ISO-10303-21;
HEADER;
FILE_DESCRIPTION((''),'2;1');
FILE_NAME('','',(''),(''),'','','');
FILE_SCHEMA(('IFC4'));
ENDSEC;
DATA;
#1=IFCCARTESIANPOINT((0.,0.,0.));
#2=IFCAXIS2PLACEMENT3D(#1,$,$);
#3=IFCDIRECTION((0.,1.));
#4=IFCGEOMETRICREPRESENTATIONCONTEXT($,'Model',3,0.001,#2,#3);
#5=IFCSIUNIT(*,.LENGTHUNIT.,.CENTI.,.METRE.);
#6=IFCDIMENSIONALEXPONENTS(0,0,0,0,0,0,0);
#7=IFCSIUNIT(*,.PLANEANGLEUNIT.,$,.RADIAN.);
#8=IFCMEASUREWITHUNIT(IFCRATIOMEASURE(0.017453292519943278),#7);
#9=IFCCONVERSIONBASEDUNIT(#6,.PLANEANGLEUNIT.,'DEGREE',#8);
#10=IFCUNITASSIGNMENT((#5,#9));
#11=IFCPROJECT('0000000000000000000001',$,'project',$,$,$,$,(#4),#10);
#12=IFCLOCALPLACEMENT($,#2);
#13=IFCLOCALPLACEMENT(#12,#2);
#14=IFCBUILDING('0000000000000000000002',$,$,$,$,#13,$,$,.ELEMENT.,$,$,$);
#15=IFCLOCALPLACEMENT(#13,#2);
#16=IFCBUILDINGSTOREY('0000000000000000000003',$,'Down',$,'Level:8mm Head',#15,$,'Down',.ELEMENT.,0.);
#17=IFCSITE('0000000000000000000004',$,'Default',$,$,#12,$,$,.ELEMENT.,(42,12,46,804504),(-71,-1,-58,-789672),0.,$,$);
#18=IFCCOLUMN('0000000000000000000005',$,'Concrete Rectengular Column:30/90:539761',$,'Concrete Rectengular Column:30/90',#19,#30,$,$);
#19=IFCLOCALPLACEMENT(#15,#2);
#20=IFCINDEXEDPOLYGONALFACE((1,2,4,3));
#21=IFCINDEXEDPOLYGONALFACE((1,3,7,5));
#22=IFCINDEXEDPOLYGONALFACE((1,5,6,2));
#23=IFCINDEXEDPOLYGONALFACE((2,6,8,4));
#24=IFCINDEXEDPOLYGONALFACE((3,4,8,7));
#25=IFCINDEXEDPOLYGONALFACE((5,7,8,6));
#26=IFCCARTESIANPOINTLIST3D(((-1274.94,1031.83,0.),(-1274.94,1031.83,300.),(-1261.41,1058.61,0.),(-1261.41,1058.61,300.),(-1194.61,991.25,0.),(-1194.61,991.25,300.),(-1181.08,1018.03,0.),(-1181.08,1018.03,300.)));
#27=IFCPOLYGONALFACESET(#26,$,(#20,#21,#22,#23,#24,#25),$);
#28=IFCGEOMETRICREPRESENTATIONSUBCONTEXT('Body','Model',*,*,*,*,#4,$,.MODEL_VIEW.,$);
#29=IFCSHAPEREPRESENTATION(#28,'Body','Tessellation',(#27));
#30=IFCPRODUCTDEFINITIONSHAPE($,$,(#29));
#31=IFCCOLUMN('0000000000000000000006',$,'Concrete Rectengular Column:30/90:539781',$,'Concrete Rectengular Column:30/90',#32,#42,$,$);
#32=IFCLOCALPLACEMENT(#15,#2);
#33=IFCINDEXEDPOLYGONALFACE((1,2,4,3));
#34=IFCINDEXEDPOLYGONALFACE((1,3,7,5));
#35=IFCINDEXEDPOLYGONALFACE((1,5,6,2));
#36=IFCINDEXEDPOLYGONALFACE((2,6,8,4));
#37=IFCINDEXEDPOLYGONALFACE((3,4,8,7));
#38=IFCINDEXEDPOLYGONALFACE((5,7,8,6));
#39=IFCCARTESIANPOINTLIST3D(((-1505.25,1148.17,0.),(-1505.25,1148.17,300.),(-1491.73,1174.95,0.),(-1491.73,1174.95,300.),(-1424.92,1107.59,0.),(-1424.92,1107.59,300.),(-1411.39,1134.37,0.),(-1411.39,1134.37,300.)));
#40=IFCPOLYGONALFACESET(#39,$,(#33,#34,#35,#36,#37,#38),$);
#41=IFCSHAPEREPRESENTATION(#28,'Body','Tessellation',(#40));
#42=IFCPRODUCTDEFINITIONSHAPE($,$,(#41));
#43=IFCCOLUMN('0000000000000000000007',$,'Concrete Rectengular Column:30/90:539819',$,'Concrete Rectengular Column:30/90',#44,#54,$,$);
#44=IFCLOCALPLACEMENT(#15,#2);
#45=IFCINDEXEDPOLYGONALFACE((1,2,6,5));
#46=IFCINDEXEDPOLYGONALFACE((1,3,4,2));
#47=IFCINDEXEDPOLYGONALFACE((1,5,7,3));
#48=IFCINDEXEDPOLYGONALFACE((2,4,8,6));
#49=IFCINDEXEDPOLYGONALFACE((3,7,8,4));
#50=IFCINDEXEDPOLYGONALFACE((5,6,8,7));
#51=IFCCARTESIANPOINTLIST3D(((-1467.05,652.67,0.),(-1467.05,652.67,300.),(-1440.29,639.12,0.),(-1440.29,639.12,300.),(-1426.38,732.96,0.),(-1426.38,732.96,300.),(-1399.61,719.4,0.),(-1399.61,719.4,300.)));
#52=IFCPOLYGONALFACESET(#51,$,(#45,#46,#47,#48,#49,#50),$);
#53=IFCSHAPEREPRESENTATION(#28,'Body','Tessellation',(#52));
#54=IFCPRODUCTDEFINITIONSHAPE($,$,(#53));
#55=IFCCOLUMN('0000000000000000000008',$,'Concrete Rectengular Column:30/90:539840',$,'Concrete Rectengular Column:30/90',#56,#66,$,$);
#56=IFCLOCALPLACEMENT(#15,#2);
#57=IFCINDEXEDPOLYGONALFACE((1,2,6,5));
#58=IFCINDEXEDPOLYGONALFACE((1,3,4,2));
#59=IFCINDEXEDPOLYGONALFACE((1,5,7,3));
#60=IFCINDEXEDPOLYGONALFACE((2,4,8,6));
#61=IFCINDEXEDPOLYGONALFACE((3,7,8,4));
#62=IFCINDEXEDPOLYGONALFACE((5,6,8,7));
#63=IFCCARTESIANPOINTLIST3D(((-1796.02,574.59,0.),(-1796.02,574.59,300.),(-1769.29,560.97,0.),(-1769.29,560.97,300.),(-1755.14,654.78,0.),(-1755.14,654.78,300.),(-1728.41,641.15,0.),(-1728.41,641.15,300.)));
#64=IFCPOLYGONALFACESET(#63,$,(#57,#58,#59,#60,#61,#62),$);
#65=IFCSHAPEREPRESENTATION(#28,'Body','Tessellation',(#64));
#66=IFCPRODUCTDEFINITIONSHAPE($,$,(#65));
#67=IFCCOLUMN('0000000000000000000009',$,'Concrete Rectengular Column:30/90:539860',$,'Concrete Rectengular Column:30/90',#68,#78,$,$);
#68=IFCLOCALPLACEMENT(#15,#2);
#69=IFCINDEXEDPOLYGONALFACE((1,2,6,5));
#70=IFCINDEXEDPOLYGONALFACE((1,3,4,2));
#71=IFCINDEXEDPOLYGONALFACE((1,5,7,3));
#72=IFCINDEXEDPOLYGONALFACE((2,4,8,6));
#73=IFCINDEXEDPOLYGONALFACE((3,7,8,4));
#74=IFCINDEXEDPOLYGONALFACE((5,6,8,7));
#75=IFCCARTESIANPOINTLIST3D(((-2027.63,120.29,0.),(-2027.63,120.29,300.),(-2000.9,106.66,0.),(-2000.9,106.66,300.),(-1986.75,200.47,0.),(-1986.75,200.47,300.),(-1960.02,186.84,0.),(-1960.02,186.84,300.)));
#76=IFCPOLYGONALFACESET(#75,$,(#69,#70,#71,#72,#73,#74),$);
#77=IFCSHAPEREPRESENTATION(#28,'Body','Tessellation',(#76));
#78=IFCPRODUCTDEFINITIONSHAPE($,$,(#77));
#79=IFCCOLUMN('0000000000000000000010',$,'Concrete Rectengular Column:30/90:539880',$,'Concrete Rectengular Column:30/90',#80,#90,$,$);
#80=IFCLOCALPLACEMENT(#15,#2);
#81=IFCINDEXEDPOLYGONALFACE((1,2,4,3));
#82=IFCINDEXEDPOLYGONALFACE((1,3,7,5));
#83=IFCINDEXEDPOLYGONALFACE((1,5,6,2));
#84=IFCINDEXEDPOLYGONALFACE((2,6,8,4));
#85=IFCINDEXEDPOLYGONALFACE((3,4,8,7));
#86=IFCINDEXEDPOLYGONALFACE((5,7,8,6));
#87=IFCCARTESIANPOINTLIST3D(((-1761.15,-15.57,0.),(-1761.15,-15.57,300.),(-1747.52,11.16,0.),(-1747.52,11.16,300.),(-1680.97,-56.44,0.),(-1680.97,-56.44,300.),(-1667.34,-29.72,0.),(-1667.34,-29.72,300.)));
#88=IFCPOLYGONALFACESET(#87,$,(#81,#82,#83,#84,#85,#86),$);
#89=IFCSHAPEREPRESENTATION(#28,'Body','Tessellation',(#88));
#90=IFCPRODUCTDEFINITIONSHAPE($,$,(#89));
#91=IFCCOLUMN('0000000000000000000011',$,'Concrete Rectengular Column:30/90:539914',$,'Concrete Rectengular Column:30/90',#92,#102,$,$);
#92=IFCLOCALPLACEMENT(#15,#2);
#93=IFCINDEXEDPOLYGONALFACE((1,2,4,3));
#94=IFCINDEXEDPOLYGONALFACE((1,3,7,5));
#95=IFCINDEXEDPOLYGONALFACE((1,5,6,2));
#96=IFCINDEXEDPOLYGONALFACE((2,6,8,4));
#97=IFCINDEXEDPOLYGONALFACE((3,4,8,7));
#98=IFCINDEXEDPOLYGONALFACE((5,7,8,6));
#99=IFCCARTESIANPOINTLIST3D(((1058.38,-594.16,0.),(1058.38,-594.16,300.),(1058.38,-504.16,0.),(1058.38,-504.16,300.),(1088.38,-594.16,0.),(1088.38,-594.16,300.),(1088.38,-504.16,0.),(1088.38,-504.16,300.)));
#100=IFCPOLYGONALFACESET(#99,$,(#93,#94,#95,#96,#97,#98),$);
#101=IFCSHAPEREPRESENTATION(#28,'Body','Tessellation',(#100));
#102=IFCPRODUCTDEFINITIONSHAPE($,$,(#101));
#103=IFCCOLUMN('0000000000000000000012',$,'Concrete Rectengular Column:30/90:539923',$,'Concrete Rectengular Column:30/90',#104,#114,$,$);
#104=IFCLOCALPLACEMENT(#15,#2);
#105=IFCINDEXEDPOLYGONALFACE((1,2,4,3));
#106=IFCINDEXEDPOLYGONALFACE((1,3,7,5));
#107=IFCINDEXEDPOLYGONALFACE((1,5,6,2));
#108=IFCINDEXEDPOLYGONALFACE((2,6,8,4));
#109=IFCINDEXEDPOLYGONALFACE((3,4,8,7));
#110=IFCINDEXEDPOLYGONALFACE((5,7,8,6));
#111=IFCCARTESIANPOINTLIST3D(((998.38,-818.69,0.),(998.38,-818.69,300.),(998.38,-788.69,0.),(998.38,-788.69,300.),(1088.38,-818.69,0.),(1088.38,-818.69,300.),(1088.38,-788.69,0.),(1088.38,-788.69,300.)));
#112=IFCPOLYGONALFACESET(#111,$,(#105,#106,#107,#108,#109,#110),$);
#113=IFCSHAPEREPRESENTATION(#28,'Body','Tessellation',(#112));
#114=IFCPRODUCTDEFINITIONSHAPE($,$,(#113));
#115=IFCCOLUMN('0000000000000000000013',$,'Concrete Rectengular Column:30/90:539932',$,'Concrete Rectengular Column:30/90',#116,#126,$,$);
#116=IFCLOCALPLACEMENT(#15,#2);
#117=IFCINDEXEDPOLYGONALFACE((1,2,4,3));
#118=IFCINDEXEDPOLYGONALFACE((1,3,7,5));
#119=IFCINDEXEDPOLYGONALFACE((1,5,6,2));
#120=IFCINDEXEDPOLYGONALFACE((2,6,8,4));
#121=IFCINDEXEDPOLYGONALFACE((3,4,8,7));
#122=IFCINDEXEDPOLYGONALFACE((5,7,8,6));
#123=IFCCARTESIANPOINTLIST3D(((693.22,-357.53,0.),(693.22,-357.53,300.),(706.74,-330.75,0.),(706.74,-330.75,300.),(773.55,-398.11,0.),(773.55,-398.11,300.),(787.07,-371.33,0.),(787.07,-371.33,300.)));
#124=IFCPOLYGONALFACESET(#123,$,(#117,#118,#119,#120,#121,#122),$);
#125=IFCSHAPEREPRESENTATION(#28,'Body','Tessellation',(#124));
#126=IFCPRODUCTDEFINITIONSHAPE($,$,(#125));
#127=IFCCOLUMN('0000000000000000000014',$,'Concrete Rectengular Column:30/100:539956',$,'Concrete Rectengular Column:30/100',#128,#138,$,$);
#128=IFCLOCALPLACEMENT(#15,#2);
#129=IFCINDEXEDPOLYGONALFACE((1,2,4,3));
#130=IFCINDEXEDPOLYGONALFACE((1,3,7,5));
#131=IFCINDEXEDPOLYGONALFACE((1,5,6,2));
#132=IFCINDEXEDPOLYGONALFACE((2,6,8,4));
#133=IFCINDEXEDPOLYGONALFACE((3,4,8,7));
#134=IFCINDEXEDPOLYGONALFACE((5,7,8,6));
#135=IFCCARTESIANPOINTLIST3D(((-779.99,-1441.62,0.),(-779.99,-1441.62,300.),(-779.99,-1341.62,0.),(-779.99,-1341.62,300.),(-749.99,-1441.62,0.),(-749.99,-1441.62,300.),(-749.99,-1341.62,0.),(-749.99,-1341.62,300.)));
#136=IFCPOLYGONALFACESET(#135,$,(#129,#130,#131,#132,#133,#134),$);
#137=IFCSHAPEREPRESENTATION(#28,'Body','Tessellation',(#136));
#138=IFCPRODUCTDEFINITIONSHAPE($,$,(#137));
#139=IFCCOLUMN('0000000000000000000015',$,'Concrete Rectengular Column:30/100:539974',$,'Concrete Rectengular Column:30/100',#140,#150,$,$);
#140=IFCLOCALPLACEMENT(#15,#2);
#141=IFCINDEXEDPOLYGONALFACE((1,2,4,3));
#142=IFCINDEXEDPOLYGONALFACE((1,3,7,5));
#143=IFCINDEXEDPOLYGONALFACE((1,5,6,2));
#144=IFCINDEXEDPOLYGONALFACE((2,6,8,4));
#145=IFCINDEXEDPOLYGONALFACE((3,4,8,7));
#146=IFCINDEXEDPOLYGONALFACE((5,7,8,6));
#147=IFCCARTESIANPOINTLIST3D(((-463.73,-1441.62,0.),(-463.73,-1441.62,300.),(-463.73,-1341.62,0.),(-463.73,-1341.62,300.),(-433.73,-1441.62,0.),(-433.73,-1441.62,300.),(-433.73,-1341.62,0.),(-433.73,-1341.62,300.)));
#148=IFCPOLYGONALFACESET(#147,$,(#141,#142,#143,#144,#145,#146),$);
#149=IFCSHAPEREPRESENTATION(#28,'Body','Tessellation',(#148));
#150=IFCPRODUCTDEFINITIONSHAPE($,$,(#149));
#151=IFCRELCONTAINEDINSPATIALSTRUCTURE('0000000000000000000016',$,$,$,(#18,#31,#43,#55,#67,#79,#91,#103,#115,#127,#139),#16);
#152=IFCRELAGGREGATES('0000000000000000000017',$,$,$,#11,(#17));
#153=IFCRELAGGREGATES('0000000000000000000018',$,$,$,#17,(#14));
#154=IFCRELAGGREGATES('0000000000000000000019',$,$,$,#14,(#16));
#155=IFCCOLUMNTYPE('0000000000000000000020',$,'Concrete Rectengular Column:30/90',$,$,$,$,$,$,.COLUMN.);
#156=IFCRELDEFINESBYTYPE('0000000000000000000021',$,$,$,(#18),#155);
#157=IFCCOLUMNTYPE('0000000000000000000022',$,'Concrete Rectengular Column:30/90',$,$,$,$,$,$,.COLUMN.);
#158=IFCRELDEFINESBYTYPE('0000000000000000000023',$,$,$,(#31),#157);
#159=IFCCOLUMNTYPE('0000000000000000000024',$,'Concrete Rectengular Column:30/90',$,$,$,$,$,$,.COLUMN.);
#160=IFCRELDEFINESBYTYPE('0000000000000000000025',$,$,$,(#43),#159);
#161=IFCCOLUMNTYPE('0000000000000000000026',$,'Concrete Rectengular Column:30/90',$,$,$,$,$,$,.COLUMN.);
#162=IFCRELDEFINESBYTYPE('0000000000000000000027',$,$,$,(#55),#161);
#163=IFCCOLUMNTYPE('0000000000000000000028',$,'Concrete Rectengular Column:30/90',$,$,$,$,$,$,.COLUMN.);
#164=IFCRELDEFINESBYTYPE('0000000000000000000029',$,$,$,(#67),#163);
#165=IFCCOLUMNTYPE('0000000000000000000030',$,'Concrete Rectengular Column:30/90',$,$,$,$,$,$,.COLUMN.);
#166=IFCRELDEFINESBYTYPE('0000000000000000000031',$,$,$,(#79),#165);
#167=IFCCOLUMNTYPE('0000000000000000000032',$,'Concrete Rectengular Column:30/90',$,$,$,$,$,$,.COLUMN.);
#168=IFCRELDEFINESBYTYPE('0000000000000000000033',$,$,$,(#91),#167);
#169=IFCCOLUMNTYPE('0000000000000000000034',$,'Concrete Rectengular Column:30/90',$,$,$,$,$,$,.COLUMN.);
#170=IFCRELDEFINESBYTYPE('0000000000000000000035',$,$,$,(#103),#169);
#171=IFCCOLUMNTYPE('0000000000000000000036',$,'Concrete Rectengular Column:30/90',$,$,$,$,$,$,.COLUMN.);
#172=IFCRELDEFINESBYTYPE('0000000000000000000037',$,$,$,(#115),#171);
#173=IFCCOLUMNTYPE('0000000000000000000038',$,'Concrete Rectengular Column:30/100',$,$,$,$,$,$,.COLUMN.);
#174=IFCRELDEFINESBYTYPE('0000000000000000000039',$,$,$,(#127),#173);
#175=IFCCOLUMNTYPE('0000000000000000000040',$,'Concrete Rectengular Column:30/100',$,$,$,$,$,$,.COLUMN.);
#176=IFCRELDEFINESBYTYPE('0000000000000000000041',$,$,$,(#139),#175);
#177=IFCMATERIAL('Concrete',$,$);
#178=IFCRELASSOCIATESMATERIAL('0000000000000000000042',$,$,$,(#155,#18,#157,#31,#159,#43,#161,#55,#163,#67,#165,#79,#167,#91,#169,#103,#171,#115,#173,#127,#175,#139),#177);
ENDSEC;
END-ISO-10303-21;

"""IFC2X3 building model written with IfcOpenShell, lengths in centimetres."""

from ifc_helpers import new_model, entity, si_unit, converted_unit, direction, frame, frame_2d, origin, origin_2d_with_axis, place, context, subcontext, project, spatial, rectangle, extrude, source, transform, mapped, material, type_object, type_shapes, element, save


model = new_model("IFC2X3")

# Units and contexts
model_context = context("Model", 3, precision=0.001, world=origin(), true_north=direction((0.0, 1.0)))
body_context = subcontext(model_context, "Body", "Model", "MODEL_VIEW")
ifc_project = project(units=[si_unit("LENGTHUNIT", "METRE", prefix="CENTI"), converted_unit("PLANEANGLEUNIT", "DEGREE", entity("IfcRatioMeasure", 0.017453292519943278), si_unit("PLANEANGLEUNIT", "RADIAN"), dimensions=[0, 0, 0, 0, 0, 0, 0])], contexts=[model_context])

# Site, building, storey
site_placement = place(None, origin())
site = spatial("IfcSite", under=ifc_project, at=site_placement, Name="Default", CompositionType="ELEMENT", RefLatitude=(42, 12, 46, 804504), RefLongitude=(-71, -1, -58, -789672), RefElevation=0.0)
building_placement = place(site_placement, origin())
building = spatial("IfcBuilding", under=site, at=building_placement, CompositionType="ELEMENT")
storey_placement = place(building_placement, origin())
storey = spatial("IfcBuildingStorey", under=building, at=storey_placement, Name="Down", ObjectType="Level:8mm Head", LongName="Down", CompositionType="ELEMENT", Elevation=0.0)

# Columns
ifc_material = material(Name="Concrete")
column_type_1 = type_object("IfcColumnType", Name="Concrete Rectengular Column:30/90", PredefinedType="COLUMN", material=ifc_material)
shared_shape_1 = source(origin(), body_context, "Body", "SweptSolid", [
    extrude(rectangle(XDim=90.0, YDim=30.0, at=origin_2d_with_axis()), frame((-1228.01, 1024.93, 0.0), z_axis=(0.0, 0.0, 1.0), x_axis=(-0.892587, 0.450875, 0.0)), (0.0, 0.0, 1.0), 300.0),
])
type_shapes(column_type_1, [shared_shape_1])
column_1_placement = place(storey_placement, origin())
element("IfcColumn", 1, at=column_1_placement, inside=storey, type_object=column_type_1, material=ifc_material, Name="Concrete Rectengular Column:30/90:539761", ObjectType="Concrete Rectengular Column:30/90", context=body_context, shape_type="MappedRepresentation", body=[
    mapped(shared_shape_1, transform((0.0, 0.0, 0.0), scale=1.0)),
])
column_type_2 = type_object("IfcColumnType", Name="Concrete Rectengular Column:30/90", PredefinedType="COLUMN", material=ifc_material)
shared_shape_2 = source(origin(), body_context, "Body", "SweptSolid", [
    extrude(rectangle(XDim=90.0, YDim=30.0, at=origin_2d_with_axis()), frame((-1458.32, 1141.27, 0.0), z_axis=(0.0, 0.0, 1.0), x_axis=(-0.892587, 0.450875, 0.0)), (0.0, 0.0, 1.0), 300.0),
])
type_shapes(column_type_2, [shared_shape_2])
column_2_placement = place(storey_placement, origin())
element("IfcColumn", 2, at=column_2_placement, inside=storey, type_object=column_type_2, material=ifc_material, Name="Concrete Rectengular Column:30/90:539781", ObjectType="Concrete Rectengular Column:30/90", context=body_context, shape_type="MappedRepresentation", body=[
    mapped(shared_shape_2, transform((0.0, 0.0, 0.0), scale=1.0)),
])
column_type_3 = type_object("IfcColumnType", Name="Concrete Rectengular Column:30/90", PredefinedType="COLUMN", material=ifc_material)
shared_shape_3 = source(origin(), body_context, "Body", "SweptSolid", [
    extrude(rectangle(XDim=30.0, YDim=90.0, at=origin_2d_with_axis()), frame((-1433.33, 686.04, 0.0), z_axis=(0.0, 0.0, 1.0), x_axis=(-0.892067, 0.451903, 0.0)), (0.0, 0.0, 1.0), 300.0),
])
type_shapes(column_type_3, [shared_shape_3])
column_3_placement = place(storey_placement, origin())
element("IfcColumn", 3, at=column_3_placement, inside=storey, type_object=column_type_3, material=ifc_material, Name="Concrete Rectengular Column:30/90:539819", ObjectType="Concrete Rectengular Column:30/90", context=body_context, shape_type="MappedRepresentation", body=[
    mapped(shared_shape_3, transform((0.0, 0.0, 0.0), scale=1.0)),
])
column_type_4 = type_object("IfcColumnType", Name="Concrete Rectengular Column:30/90", PredefinedType="COLUMN", material=ifc_material)
shared_shape_4 = source(origin(), body_context, "Body", "SweptSolid", [
    extrude(rectangle(XDim=30.0, YDim=90.0, at=frame_2d((0.0, 0.0), x_axis=(1.0, 0.0))), frame((-1762.22, 607.87, 0.0), z_axis=(0.0, 0.0, 1.0), x_axis=(-0.890906, 0.454187, 0.0)), (0.0, 0.0, 1.0), 300.0),
])
type_shapes(column_type_4, [shared_shape_4])
column_4_placement = place(storey_placement, origin())
element("IfcColumn", 4, at=column_4_placement, inside=storey, type_object=column_type_4, material=ifc_material, Name="Concrete Rectengular Column:30/90:539840", ObjectType="Concrete Rectengular Column:30/90", context=body_context, shape_type="MappedRepresentation", body=[
    mapped(shared_shape_4, transform((0.0, 0.0, 0.0), scale=1.0)),
])
column_type_5 = type_object("IfcColumnType", Name="Concrete Rectengular Column:30/90", PredefinedType="COLUMN", material=ifc_material)
shared_shape_5 = source(origin(), body_context, "Body", "SweptSolid", [
    extrude(rectangle(XDim=30.0, YDim=90.0, at=origin_2d_with_axis()), frame((-1993.82, 153.56, 0.0), z_axis=(0.0, 0.0, 1.0), x_axis=(-0.890906, 0.454187, 0.0)), (0.0, 0.0, 1.0), 300.0),
])
type_shapes(column_type_5, [shared_shape_5])
column_5_placement = place(storey_placement, origin())
element("IfcColumn", 5, at=column_5_placement, inside=storey, type_object=column_type_5, material=ifc_material, Name="Concrete Rectengular Column:30/90:539860", ObjectType="Concrete Rectengular Column:30/90", context=body_context, shape_type="MappedRepresentation", body=[
    mapped(shared_shape_5, transform((0.0, 0.0, 0.0), scale=1.0)),
])
column_type_6 = type_object("IfcColumnType", Name="Concrete Rectengular Column:30/90", PredefinedType="COLUMN", material=ifc_material)
shared_shape_6 = source(origin(), body_context, "Body", "SweptSolid", [
    extrude(rectangle(XDim=90.0, YDim=30.0, at=frame_2d((0.0, 0.0), x_axis=(1.0, 0.0))), frame((-1714.24, -22.64, 0.0), z_axis=(0.0, 0.0, 1.0), x_axis=(-0.890906, 0.454187, 0.0)), (0.0, 0.0, 1.0), 300.0),
])
type_shapes(column_type_6, [shared_shape_6])
column_6_placement = place(storey_placement, origin())
element("IfcColumn", 6, at=column_6_placement, inside=storey, type_object=column_type_6, material=ifc_material, Name="Concrete Rectengular Column:30/90:539880", ObjectType="Concrete Rectengular Column:30/90", context=body_context, shape_type="MappedRepresentation", body=[
    mapped(shared_shape_6, transform((0.0, 0.0, 0.0), scale=1.0)),
])
column_type_7 = type_object("IfcColumnType", Name="Concrete Rectengular Column:30/90", PredefinedType="COLUMN", material=ifc_material)
shared_shape_7 = source(origin(), body_context, "Body", "SweptSolid", [
    extrude(rectangle(XDim=90.0, YDim=30.0, at=frame_2d((0.0, 0.0), x_axis=(1.0, 0.0))), frame((1073.38, -549.16, 0.0), z_axis=(0.0, 0.0, 1.0), x_axis=(0.0, -1.0, 0.0)), (0.0, 0.0, 1.0), 300.0),
])
type_shapes(column_type_7, [shared_shape_7])
column_7_placement = place(storey_placement, origin())
element("IfcColumn", 7, at=column_7_placement, inside=storey, type_object=column_type_7, material=ifc_material, Name="Concrete Rectengular Column:30/90:539914", ObjectType="Concrete Rectengular Column:30/90", context=body_context, shape_type="MappedRepresentation", body=[
    mapped(shared_shape_7, transform((0.0, 0.0, 0.0), scale=1.0)),
])
column_type_8 = type_object("IfcColumnType", Name="Concrete Rectengular Column:30/90", PredefinedType="COLUMN", material=ifc_material)
shared_shape_8 = source(origin(), body_context, "Body", "SweptSolid", [
    extrude(rectangle(XDim=30.0, YDim=90.0, at=frame_2d((0.0, 0.0), x_axis=(1.0, 0.0))), frame((1043.38, -803.69, 0.0), z_axis=(0.0, 0.0, 1.0), x_axis=(0.0, -1.0, 0.0)), (0.0, 0.0, 1.0), 300.0),
])
type_shapes(column_type_8, [shared_shape_8])
column_8_placement = place(storey_placement, origin())
element("IfcColumn", 8, at=column_8_placement, inside=storey, type_object=column_type_8, material=ifc_material, Name="Concrete Rectengular Column:30/90:539923", ObjectType="Concrete Rectengular Column:30/90", context=body_context, shape_type="MappedRepresentation", body=[
    mapped(shared_shape_8, transform((0.0, 0.0, 0.0), scale=1.0)),
])
column_type_9 = type_object("IfcColumnType", Name="Concrete Rectengular Column:30/90", PredefinedType="COLUMN", material=ifc_material)
shared_shape_9 = source(origin(), body_context, "Body", "SweptSolid", [
    extrude(rectangle(XDim=90.0, YDim=30.0, at=frame_2d((0.0, 0.0), x_axis=(1.0, 0.0))), frame((740.14, -364.43, 0.0), z_axis=(0.0, 0.0, 1.0), x_axis=(-0.892587, 0.450875, 0.0)), (0.0, 0.0, 1.0), 300.0),
])
type_shapes(column_type_9, [shared_shape_9])
column_9_placement = place(storey_placement, origin())
element("IfcColumn", 9, at=column_9_placement, inside=storey, type_object=column_type_9, material=ifc_material, Name="Concrete Rectengular Column:30/90:539932", ObjectType="Concrete Rectengular Column:30/90", context=body_context, shape_type="MappedRepresentation", body=[
    mapped(shared_shape_9, transform((0.0, 0.0, 0.0), scale=1.0)),
])
column_type_10 = type_object("IfcColumnType", Name="Concrete Rectengular Column:30/100", PredefinedType="COLUMN", material=ifc_material)
shared_shape_10 = source(origin(), body_context, "Body", "SweptSolid", [
    extrude(rectangle(XDim=100.0, YDim=30.0, at=frame_2d((0.0, 0.0), x_axis=(1.0, 0.0))), frame((-764.99, -1391.62, 0.0), z_axis=(0.0, 0.0, 1.0), x_axis=(0.0, -1.0, 0.0)), (0.0, 0.0, 1.0), 300.0),
])
type_shapes(column_type_10, [shared_shape_10])
column_10_placement = place(storey_placement, origin())
element("IfcColumn", 10, at=column_10_placement, inside=storey, type_object=column_type_10, material=ifc_material, Name="Concrete Rectengular Column:30/100:539956", ObjectType="Concrete Rectengular Column:30/100", context=body_context, shape_type="MappedRepresentation", body=[
    mapped(shared_shape_10, transform((0.0, 0.0, 0.0), scale=1.0)),
])
column_type_11 = type_object("IfcColumnType", Name="Concrete Rectengular Column:30/100", PredefinedType="COLUMN", material=ifc_material)
shared_shape_11 = source(origin(), body_context, "Body", "SweptSolid", [
    extrude(rectangle(XDim=100.0, YDim=30.0, at=frame_2d((0.0, 0.0), x_axis=(1.0, 0.0))), frame((-448.73, -1391.62, 0.0), z_axis=(0.0, 0.0, 1.0), x_axis=(0.0, -1.0, 0.0)), (0.0, 0.0, 1.0), 300.0),
])
type_shapes(column_type_11, [shared_shape_11])
column_11_placement = place(storey_placement, origin())
element("IfcColumn", 11, at=column_11_placement, inside=storey, type_object=column_type_11, material=ifc_material, Name="Concrete Rectengular Column:30/100:539974", ObjectType="Concrete Rectengular Column:30/100", context=body_context, shape_type="MappedRepresentation", body=[
    mapped(shared_shape_11, transform((0.0, 0.0, 0.0), scale=1.0)),
])

save(model, "model.ifc")
